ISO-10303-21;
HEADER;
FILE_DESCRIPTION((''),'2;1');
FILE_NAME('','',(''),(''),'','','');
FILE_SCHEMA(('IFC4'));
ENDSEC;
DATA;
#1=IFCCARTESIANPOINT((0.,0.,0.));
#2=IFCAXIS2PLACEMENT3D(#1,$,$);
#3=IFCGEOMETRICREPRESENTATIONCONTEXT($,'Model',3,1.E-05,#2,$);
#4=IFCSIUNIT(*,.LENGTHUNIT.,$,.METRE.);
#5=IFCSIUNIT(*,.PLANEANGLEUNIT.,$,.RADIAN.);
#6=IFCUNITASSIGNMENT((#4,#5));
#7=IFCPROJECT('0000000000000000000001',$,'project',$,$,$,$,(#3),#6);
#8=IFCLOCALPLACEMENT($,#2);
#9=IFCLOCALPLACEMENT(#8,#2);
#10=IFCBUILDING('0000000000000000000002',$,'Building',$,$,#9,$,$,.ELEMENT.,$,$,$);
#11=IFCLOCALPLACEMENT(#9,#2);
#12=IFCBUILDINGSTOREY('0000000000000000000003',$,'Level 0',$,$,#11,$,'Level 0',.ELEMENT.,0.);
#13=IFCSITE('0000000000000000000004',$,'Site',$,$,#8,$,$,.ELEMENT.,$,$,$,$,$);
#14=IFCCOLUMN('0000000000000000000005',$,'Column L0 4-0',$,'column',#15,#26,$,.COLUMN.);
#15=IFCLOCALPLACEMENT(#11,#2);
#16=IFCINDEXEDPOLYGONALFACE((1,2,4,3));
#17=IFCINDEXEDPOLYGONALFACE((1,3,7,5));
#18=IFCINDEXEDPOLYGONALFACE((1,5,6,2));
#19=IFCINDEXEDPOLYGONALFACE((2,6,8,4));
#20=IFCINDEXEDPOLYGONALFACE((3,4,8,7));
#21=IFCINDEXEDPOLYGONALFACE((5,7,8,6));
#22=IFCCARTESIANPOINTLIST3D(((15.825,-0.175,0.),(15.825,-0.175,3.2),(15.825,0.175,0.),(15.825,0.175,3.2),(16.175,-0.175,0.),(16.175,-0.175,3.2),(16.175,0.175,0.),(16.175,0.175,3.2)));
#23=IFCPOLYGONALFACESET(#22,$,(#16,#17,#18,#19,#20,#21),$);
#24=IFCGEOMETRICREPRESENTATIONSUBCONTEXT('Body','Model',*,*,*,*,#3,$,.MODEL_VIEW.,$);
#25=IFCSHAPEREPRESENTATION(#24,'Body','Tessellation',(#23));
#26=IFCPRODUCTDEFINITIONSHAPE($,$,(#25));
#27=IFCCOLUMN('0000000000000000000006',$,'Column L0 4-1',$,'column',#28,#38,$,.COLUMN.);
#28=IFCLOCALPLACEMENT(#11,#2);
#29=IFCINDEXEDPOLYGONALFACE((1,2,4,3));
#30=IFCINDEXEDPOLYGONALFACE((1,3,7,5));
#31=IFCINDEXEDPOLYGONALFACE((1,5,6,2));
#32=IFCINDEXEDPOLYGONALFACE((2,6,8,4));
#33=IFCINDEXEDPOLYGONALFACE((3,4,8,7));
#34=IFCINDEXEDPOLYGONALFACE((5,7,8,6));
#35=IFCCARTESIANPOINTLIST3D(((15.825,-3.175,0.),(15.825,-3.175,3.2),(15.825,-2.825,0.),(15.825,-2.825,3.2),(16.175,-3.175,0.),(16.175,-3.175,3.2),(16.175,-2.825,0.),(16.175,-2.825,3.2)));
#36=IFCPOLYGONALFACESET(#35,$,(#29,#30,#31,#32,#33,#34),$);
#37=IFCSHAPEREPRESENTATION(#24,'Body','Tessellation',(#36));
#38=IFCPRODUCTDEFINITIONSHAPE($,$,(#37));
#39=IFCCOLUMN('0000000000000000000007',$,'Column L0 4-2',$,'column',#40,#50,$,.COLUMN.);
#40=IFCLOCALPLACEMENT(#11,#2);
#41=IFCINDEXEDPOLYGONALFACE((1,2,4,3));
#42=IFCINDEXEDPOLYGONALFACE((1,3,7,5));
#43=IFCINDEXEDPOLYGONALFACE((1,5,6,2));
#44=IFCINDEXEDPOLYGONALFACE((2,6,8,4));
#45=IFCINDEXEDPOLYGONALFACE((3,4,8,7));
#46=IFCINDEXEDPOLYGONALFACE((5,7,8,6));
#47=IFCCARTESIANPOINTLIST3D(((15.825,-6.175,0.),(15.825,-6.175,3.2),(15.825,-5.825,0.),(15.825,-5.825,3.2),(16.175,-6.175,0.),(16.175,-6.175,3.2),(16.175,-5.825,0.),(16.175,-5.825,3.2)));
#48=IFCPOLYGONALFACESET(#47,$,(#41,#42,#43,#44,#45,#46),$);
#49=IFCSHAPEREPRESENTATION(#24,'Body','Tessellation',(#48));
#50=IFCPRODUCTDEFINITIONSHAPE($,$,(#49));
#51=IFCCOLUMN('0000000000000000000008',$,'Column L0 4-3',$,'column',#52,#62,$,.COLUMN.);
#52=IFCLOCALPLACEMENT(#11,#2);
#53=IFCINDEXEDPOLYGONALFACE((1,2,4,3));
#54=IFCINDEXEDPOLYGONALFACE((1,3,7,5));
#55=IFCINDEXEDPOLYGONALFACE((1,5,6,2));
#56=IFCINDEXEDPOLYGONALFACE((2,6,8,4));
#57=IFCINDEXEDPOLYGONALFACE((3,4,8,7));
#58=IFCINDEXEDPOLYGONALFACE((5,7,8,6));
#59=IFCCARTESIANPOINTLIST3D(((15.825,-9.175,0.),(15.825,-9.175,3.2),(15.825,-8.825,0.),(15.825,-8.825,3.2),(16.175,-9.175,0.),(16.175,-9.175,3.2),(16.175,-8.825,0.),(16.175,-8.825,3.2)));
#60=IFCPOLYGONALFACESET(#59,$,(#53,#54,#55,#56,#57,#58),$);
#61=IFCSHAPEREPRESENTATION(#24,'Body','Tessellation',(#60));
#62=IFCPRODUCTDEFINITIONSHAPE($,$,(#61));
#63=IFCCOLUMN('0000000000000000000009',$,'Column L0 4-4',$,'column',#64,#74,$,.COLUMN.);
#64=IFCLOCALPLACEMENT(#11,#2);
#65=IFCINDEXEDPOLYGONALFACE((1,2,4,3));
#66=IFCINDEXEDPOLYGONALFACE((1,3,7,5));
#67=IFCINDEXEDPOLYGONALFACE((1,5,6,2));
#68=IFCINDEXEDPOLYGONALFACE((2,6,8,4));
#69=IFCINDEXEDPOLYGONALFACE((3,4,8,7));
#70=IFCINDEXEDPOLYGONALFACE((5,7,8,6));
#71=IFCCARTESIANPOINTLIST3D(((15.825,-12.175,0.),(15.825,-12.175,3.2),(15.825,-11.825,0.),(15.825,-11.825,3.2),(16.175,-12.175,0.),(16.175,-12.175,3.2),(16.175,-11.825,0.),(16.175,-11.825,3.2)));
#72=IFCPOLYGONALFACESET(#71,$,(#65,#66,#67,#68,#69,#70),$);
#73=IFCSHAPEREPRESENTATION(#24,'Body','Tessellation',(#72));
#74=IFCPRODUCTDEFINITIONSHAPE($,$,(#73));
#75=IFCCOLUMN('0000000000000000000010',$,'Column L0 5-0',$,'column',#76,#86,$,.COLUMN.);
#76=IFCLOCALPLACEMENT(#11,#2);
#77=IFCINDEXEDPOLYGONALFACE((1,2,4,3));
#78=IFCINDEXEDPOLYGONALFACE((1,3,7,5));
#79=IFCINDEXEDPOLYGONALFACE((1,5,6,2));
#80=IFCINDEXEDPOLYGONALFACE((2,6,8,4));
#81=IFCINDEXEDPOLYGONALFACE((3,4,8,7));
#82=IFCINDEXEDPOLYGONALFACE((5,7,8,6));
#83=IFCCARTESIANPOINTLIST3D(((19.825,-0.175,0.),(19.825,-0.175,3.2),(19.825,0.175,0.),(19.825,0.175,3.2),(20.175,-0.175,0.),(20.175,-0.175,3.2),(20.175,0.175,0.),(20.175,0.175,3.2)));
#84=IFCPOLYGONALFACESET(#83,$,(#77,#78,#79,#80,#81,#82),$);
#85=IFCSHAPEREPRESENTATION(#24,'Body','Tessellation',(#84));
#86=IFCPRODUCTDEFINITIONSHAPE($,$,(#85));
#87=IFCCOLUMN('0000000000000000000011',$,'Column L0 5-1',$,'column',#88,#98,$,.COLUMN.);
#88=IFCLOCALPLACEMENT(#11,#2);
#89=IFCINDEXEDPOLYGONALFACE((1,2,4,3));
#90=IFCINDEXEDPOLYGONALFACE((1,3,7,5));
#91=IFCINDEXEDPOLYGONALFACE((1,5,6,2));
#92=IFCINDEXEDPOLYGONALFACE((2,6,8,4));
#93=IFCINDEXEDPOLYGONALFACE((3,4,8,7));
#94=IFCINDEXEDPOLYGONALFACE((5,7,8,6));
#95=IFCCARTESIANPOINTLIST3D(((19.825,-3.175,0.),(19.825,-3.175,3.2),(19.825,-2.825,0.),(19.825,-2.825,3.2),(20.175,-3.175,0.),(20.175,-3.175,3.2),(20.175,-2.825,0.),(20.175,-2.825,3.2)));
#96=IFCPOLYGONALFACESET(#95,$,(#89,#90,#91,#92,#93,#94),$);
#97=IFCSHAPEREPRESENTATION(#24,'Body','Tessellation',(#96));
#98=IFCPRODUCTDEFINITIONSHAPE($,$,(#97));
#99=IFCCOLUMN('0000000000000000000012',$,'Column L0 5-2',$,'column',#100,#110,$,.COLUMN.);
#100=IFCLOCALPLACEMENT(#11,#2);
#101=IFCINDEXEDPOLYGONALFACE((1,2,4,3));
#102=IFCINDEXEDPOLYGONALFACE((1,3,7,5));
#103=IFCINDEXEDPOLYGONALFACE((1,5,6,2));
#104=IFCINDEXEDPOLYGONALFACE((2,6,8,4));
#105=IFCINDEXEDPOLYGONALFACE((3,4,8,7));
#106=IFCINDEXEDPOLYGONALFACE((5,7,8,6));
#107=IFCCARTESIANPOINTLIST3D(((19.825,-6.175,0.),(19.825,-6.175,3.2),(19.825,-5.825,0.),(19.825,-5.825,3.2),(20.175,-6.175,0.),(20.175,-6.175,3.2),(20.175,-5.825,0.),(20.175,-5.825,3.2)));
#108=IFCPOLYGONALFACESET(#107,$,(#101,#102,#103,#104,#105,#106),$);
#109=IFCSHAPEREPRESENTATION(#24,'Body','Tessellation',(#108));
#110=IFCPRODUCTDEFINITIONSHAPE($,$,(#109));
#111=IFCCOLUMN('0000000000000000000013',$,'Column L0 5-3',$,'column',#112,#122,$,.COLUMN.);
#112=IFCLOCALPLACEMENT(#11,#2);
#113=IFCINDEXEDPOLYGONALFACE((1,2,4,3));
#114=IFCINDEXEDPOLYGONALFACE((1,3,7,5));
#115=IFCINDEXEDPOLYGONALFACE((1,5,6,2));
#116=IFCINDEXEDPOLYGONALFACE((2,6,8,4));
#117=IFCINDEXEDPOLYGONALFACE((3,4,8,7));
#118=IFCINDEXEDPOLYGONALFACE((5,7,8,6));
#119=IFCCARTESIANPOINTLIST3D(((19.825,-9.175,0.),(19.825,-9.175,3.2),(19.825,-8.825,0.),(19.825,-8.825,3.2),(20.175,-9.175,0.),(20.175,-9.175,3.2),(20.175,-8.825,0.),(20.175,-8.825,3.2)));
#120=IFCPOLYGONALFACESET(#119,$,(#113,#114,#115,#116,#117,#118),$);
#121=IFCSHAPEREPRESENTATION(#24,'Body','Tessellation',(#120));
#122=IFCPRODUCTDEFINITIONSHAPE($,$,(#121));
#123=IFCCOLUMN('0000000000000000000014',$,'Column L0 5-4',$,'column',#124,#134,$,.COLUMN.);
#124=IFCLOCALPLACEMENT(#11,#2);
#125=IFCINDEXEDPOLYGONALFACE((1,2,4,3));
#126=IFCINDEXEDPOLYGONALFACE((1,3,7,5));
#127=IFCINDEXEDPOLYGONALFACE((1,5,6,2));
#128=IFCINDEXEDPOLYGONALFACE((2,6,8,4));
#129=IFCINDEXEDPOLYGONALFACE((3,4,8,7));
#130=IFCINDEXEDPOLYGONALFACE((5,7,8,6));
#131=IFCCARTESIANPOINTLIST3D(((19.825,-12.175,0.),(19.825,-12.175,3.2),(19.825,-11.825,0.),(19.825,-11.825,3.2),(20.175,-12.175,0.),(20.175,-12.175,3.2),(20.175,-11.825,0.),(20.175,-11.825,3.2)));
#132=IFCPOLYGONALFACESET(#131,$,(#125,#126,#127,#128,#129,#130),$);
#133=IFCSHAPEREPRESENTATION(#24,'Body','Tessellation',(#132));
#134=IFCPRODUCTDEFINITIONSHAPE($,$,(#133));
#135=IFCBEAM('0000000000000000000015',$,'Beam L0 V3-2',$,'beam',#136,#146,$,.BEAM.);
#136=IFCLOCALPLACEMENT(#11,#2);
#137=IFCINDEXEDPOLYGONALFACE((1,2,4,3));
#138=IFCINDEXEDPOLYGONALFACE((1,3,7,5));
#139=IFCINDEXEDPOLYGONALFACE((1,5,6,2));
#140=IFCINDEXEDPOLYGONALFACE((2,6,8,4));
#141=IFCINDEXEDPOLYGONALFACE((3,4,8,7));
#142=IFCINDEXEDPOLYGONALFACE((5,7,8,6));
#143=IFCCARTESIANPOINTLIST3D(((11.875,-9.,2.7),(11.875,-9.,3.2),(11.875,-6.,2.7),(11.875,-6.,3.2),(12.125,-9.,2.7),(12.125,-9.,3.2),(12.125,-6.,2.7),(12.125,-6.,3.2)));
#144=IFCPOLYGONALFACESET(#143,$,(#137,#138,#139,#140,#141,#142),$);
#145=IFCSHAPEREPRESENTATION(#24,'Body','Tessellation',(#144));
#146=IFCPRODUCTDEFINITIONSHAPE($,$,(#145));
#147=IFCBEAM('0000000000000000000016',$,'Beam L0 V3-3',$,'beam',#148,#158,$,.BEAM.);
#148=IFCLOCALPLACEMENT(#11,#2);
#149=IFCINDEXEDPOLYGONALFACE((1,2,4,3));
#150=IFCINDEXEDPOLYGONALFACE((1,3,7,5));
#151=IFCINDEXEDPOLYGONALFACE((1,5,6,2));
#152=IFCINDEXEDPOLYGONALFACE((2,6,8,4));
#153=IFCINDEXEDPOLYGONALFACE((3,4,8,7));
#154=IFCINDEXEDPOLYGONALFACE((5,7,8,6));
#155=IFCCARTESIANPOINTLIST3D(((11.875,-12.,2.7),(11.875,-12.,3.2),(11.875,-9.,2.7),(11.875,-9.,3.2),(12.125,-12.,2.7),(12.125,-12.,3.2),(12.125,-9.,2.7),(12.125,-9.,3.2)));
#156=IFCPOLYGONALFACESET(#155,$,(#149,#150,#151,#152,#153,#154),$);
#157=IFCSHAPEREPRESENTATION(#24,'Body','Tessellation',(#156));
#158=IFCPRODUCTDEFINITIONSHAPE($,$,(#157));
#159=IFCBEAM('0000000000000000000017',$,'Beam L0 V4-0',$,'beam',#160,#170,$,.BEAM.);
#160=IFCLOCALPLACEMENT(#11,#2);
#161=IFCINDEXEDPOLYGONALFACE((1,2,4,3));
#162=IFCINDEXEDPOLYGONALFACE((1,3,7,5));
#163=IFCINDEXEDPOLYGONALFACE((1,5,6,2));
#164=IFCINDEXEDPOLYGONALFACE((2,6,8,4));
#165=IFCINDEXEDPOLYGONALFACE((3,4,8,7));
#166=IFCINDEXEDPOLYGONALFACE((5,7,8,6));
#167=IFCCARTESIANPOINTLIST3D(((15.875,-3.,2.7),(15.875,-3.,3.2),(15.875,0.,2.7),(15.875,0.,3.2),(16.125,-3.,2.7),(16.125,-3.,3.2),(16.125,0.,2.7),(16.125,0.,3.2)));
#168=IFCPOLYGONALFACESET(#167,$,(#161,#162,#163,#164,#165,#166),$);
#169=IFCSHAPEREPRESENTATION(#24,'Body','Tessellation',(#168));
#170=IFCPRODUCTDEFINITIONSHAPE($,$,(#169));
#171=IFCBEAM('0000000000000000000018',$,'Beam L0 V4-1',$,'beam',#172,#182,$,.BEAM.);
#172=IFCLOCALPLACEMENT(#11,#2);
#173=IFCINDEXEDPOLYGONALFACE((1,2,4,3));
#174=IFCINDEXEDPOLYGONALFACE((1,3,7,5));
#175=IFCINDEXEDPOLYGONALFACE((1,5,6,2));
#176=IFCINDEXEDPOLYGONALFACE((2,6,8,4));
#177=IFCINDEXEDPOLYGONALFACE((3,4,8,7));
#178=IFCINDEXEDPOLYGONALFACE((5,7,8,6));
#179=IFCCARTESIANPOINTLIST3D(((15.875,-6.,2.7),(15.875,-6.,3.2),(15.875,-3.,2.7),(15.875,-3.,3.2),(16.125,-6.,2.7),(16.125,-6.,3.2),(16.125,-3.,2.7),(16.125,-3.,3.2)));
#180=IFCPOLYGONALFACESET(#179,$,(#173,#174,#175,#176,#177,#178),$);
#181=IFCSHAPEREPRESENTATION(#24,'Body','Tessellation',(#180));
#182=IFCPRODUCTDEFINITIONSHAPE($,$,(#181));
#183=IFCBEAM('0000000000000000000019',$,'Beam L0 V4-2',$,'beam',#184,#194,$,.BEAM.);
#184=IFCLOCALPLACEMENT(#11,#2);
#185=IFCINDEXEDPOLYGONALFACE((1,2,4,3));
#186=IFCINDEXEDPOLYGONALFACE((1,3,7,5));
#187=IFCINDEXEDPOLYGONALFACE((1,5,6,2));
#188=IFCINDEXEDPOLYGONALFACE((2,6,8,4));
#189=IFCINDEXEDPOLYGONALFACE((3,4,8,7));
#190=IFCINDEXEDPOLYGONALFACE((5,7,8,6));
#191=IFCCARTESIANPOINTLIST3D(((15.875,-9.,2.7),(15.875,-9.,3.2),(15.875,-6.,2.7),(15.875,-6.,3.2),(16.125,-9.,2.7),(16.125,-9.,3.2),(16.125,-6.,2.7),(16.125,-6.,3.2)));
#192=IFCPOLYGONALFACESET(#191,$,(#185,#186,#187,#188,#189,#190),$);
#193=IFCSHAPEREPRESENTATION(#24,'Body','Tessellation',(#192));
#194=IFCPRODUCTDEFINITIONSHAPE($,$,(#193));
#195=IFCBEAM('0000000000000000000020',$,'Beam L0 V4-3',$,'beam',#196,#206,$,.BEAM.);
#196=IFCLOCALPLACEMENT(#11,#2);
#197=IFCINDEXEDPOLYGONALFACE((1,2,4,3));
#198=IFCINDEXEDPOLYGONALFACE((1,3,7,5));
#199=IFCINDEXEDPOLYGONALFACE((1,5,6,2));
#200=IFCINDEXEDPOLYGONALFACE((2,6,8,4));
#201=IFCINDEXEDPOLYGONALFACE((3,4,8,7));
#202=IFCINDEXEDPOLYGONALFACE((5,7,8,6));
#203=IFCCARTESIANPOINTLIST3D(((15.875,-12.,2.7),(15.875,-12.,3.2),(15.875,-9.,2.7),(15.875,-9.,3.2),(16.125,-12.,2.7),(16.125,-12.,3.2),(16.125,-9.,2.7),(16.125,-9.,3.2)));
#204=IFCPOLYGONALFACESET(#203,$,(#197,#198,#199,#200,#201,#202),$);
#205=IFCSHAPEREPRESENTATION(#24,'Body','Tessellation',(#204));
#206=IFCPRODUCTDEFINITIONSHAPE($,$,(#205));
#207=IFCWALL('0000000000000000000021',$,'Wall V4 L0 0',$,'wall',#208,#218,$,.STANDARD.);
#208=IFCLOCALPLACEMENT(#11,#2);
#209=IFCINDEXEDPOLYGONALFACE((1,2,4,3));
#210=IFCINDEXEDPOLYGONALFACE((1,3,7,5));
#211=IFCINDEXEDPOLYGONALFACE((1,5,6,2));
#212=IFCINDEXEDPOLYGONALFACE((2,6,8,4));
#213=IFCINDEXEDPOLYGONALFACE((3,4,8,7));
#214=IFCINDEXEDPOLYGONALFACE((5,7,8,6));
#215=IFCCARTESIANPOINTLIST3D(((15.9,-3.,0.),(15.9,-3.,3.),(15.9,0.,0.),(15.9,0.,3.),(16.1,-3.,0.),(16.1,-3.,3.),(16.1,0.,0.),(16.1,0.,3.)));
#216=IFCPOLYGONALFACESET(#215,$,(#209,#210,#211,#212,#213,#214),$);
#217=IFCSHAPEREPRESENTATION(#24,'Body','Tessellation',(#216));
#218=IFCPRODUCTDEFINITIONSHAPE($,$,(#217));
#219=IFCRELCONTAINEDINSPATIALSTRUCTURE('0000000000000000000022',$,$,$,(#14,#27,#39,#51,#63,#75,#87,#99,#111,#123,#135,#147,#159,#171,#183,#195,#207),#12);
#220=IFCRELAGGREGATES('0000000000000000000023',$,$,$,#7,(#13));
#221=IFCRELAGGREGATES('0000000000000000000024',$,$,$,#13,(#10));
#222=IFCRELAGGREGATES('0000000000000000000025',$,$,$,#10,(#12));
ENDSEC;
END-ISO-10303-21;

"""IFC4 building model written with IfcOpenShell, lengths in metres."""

from ifc_helpers import new_model, si_unit, frame, frame_2d, origin, origin_2d, place, context, subcontext, project, spatial, rectangle, extrude, element, save


model = new_model("IFC4")

# Units and contexts
model_context = context("Model", 3, precision=1e-05, world=origin())
body_context = subcontext(model_context, "Body", "Model", "MODEL_VIEW")
ifc_project = project(units=[si_unit("LENGTHUNIT", "METRE"), si_unit("PLANEANGLEUNIT", "RADIAN")], contexts=[model_context])

# Site, building, storey
site_placement = place(None, origin())
site = spatial("IfcSite", under=ifc_project, at=site_placement, Name="Site", CompositionType="ELEMENT")
building_placement = place(site_placement, origin())
building = spatial("IfcBuilding", under=site, at=building_placement, Name="Building", CompositionType="ELEMENT")
storey_placement = place(building_placement, origin())
storey = spatial("IfcBuildingStorey", under=building, at=storey_placement, Name="Level 0", LongName="Level 0", CompositionType="ELEMENT", Elevation=0.0)

# Columns
for number, where, name in (
    (1, (16.0, 0.0, 0.0), "Column L0 4-0"),
    (2, (16.0, -3.0, 0.0), "Column L0 4-1"),
    (3, (16.0, -6.0, 0.0), "Column L0 4-2"),
    (4, (16.0, -9.0, 0.0), "Column L0 4-3"),
    (5, (16.0, -12.0, 0.0), "Column L0 4-4"),
    (6, (20.0, 0.0, 0.0), "Column L0 5-0"),
    (7, (20.0, -3.0, 0.0), "Column L0 5-1"),
    (8, (20.0, -6.0, 0.0), "Column L0 5-2"),
    (9, (20.0, -9.0, 0.0), "Column L0 5-3"),
    (10, (20.0, -12.0, 0.0), "Column L0 5-4"),
):
    element("IfcColumn", number, at=place(storey_placement, frame(where)), inside=storey, Name=name, ObjectType="column", PredefinedType="COLUMN", context=body_context, shape_type="SweptSolid", body=[
        extrude(rectangle(XDim=0.35, YDim=0.35, at=origin_2d()), origin(), (0.0, 0.0, 1.0), 3.2),
    ])

# Beams
for number, where, z_axis, x_axis, name in (
    (11, (12.0, -6.0, 2.95), (0.0, -1.0, 0.0), (0.0, 0.0, 1.0), "Beam L0 V3-2"),
    (12, (12.0, -9.0, 2.95), (0.0, -1.0, 0.0), (0.0, 0.0, 1.0), "Beam L0 V3-3"),
    (13, (16.0, 0.0, 2.95), (0.0, -1.0, 0.0), (0.0, 0.0, 1.0), "Beam L0 V4-0"),
    (14, (16.0, -3.0, 2.95), (0.0, -1.0, 0.0), (0.0, 0.0, 1.0), "Beam L0 V4-1"),
    (15, (16.0, -6.0, 2.95), (0.0, -1.0, 0.0), (0.0, 0.0, 1.0), "Beam L0 V4-2"),
    (16, (16.0, -9.0, 2.95), (0.0, -1.0, 0.0), (0.0, 0.0, 1.0), "Beam L0 V4-3"),
):
    element("IfcBeam", number, at=place(storey_placement, frame(where, z_axis=z_axis, x_axis=x_axis)), inside=storey, Name=name, ObjectType="beam", PredefinedType="BEAM", context=body_context, shape_type="SweptSolid", body=[
        extrude(rectangle(XDim=0.5, YDim=0.25, at=origin_2d()), origin(), (0.0, 0.0, 1.0), 3.0),
    ])

# Wall
wall_1_placement = place(storey_placement, frame((16.0, 0.0, 0.0), z_axis=(0.0, 0.0, 1.0), x_axis=(0.0, -1.0, 0.0)))
element("IfcWall", 17, at=wall_1_placement, inside=storey, Name="Wall V4 L0 0", ObjectType="wall", PredefinedType="STANDARD", context=body_context, shape_type="SweptSolid", body=[
    extrude(rectangle(XDim=3.0, YDim=0.2, at=frame_2d((1.5, 0.0))), origin(), (0.0, 0.0, 1.0), 3.0),
])

save(model, "model.ifc")
